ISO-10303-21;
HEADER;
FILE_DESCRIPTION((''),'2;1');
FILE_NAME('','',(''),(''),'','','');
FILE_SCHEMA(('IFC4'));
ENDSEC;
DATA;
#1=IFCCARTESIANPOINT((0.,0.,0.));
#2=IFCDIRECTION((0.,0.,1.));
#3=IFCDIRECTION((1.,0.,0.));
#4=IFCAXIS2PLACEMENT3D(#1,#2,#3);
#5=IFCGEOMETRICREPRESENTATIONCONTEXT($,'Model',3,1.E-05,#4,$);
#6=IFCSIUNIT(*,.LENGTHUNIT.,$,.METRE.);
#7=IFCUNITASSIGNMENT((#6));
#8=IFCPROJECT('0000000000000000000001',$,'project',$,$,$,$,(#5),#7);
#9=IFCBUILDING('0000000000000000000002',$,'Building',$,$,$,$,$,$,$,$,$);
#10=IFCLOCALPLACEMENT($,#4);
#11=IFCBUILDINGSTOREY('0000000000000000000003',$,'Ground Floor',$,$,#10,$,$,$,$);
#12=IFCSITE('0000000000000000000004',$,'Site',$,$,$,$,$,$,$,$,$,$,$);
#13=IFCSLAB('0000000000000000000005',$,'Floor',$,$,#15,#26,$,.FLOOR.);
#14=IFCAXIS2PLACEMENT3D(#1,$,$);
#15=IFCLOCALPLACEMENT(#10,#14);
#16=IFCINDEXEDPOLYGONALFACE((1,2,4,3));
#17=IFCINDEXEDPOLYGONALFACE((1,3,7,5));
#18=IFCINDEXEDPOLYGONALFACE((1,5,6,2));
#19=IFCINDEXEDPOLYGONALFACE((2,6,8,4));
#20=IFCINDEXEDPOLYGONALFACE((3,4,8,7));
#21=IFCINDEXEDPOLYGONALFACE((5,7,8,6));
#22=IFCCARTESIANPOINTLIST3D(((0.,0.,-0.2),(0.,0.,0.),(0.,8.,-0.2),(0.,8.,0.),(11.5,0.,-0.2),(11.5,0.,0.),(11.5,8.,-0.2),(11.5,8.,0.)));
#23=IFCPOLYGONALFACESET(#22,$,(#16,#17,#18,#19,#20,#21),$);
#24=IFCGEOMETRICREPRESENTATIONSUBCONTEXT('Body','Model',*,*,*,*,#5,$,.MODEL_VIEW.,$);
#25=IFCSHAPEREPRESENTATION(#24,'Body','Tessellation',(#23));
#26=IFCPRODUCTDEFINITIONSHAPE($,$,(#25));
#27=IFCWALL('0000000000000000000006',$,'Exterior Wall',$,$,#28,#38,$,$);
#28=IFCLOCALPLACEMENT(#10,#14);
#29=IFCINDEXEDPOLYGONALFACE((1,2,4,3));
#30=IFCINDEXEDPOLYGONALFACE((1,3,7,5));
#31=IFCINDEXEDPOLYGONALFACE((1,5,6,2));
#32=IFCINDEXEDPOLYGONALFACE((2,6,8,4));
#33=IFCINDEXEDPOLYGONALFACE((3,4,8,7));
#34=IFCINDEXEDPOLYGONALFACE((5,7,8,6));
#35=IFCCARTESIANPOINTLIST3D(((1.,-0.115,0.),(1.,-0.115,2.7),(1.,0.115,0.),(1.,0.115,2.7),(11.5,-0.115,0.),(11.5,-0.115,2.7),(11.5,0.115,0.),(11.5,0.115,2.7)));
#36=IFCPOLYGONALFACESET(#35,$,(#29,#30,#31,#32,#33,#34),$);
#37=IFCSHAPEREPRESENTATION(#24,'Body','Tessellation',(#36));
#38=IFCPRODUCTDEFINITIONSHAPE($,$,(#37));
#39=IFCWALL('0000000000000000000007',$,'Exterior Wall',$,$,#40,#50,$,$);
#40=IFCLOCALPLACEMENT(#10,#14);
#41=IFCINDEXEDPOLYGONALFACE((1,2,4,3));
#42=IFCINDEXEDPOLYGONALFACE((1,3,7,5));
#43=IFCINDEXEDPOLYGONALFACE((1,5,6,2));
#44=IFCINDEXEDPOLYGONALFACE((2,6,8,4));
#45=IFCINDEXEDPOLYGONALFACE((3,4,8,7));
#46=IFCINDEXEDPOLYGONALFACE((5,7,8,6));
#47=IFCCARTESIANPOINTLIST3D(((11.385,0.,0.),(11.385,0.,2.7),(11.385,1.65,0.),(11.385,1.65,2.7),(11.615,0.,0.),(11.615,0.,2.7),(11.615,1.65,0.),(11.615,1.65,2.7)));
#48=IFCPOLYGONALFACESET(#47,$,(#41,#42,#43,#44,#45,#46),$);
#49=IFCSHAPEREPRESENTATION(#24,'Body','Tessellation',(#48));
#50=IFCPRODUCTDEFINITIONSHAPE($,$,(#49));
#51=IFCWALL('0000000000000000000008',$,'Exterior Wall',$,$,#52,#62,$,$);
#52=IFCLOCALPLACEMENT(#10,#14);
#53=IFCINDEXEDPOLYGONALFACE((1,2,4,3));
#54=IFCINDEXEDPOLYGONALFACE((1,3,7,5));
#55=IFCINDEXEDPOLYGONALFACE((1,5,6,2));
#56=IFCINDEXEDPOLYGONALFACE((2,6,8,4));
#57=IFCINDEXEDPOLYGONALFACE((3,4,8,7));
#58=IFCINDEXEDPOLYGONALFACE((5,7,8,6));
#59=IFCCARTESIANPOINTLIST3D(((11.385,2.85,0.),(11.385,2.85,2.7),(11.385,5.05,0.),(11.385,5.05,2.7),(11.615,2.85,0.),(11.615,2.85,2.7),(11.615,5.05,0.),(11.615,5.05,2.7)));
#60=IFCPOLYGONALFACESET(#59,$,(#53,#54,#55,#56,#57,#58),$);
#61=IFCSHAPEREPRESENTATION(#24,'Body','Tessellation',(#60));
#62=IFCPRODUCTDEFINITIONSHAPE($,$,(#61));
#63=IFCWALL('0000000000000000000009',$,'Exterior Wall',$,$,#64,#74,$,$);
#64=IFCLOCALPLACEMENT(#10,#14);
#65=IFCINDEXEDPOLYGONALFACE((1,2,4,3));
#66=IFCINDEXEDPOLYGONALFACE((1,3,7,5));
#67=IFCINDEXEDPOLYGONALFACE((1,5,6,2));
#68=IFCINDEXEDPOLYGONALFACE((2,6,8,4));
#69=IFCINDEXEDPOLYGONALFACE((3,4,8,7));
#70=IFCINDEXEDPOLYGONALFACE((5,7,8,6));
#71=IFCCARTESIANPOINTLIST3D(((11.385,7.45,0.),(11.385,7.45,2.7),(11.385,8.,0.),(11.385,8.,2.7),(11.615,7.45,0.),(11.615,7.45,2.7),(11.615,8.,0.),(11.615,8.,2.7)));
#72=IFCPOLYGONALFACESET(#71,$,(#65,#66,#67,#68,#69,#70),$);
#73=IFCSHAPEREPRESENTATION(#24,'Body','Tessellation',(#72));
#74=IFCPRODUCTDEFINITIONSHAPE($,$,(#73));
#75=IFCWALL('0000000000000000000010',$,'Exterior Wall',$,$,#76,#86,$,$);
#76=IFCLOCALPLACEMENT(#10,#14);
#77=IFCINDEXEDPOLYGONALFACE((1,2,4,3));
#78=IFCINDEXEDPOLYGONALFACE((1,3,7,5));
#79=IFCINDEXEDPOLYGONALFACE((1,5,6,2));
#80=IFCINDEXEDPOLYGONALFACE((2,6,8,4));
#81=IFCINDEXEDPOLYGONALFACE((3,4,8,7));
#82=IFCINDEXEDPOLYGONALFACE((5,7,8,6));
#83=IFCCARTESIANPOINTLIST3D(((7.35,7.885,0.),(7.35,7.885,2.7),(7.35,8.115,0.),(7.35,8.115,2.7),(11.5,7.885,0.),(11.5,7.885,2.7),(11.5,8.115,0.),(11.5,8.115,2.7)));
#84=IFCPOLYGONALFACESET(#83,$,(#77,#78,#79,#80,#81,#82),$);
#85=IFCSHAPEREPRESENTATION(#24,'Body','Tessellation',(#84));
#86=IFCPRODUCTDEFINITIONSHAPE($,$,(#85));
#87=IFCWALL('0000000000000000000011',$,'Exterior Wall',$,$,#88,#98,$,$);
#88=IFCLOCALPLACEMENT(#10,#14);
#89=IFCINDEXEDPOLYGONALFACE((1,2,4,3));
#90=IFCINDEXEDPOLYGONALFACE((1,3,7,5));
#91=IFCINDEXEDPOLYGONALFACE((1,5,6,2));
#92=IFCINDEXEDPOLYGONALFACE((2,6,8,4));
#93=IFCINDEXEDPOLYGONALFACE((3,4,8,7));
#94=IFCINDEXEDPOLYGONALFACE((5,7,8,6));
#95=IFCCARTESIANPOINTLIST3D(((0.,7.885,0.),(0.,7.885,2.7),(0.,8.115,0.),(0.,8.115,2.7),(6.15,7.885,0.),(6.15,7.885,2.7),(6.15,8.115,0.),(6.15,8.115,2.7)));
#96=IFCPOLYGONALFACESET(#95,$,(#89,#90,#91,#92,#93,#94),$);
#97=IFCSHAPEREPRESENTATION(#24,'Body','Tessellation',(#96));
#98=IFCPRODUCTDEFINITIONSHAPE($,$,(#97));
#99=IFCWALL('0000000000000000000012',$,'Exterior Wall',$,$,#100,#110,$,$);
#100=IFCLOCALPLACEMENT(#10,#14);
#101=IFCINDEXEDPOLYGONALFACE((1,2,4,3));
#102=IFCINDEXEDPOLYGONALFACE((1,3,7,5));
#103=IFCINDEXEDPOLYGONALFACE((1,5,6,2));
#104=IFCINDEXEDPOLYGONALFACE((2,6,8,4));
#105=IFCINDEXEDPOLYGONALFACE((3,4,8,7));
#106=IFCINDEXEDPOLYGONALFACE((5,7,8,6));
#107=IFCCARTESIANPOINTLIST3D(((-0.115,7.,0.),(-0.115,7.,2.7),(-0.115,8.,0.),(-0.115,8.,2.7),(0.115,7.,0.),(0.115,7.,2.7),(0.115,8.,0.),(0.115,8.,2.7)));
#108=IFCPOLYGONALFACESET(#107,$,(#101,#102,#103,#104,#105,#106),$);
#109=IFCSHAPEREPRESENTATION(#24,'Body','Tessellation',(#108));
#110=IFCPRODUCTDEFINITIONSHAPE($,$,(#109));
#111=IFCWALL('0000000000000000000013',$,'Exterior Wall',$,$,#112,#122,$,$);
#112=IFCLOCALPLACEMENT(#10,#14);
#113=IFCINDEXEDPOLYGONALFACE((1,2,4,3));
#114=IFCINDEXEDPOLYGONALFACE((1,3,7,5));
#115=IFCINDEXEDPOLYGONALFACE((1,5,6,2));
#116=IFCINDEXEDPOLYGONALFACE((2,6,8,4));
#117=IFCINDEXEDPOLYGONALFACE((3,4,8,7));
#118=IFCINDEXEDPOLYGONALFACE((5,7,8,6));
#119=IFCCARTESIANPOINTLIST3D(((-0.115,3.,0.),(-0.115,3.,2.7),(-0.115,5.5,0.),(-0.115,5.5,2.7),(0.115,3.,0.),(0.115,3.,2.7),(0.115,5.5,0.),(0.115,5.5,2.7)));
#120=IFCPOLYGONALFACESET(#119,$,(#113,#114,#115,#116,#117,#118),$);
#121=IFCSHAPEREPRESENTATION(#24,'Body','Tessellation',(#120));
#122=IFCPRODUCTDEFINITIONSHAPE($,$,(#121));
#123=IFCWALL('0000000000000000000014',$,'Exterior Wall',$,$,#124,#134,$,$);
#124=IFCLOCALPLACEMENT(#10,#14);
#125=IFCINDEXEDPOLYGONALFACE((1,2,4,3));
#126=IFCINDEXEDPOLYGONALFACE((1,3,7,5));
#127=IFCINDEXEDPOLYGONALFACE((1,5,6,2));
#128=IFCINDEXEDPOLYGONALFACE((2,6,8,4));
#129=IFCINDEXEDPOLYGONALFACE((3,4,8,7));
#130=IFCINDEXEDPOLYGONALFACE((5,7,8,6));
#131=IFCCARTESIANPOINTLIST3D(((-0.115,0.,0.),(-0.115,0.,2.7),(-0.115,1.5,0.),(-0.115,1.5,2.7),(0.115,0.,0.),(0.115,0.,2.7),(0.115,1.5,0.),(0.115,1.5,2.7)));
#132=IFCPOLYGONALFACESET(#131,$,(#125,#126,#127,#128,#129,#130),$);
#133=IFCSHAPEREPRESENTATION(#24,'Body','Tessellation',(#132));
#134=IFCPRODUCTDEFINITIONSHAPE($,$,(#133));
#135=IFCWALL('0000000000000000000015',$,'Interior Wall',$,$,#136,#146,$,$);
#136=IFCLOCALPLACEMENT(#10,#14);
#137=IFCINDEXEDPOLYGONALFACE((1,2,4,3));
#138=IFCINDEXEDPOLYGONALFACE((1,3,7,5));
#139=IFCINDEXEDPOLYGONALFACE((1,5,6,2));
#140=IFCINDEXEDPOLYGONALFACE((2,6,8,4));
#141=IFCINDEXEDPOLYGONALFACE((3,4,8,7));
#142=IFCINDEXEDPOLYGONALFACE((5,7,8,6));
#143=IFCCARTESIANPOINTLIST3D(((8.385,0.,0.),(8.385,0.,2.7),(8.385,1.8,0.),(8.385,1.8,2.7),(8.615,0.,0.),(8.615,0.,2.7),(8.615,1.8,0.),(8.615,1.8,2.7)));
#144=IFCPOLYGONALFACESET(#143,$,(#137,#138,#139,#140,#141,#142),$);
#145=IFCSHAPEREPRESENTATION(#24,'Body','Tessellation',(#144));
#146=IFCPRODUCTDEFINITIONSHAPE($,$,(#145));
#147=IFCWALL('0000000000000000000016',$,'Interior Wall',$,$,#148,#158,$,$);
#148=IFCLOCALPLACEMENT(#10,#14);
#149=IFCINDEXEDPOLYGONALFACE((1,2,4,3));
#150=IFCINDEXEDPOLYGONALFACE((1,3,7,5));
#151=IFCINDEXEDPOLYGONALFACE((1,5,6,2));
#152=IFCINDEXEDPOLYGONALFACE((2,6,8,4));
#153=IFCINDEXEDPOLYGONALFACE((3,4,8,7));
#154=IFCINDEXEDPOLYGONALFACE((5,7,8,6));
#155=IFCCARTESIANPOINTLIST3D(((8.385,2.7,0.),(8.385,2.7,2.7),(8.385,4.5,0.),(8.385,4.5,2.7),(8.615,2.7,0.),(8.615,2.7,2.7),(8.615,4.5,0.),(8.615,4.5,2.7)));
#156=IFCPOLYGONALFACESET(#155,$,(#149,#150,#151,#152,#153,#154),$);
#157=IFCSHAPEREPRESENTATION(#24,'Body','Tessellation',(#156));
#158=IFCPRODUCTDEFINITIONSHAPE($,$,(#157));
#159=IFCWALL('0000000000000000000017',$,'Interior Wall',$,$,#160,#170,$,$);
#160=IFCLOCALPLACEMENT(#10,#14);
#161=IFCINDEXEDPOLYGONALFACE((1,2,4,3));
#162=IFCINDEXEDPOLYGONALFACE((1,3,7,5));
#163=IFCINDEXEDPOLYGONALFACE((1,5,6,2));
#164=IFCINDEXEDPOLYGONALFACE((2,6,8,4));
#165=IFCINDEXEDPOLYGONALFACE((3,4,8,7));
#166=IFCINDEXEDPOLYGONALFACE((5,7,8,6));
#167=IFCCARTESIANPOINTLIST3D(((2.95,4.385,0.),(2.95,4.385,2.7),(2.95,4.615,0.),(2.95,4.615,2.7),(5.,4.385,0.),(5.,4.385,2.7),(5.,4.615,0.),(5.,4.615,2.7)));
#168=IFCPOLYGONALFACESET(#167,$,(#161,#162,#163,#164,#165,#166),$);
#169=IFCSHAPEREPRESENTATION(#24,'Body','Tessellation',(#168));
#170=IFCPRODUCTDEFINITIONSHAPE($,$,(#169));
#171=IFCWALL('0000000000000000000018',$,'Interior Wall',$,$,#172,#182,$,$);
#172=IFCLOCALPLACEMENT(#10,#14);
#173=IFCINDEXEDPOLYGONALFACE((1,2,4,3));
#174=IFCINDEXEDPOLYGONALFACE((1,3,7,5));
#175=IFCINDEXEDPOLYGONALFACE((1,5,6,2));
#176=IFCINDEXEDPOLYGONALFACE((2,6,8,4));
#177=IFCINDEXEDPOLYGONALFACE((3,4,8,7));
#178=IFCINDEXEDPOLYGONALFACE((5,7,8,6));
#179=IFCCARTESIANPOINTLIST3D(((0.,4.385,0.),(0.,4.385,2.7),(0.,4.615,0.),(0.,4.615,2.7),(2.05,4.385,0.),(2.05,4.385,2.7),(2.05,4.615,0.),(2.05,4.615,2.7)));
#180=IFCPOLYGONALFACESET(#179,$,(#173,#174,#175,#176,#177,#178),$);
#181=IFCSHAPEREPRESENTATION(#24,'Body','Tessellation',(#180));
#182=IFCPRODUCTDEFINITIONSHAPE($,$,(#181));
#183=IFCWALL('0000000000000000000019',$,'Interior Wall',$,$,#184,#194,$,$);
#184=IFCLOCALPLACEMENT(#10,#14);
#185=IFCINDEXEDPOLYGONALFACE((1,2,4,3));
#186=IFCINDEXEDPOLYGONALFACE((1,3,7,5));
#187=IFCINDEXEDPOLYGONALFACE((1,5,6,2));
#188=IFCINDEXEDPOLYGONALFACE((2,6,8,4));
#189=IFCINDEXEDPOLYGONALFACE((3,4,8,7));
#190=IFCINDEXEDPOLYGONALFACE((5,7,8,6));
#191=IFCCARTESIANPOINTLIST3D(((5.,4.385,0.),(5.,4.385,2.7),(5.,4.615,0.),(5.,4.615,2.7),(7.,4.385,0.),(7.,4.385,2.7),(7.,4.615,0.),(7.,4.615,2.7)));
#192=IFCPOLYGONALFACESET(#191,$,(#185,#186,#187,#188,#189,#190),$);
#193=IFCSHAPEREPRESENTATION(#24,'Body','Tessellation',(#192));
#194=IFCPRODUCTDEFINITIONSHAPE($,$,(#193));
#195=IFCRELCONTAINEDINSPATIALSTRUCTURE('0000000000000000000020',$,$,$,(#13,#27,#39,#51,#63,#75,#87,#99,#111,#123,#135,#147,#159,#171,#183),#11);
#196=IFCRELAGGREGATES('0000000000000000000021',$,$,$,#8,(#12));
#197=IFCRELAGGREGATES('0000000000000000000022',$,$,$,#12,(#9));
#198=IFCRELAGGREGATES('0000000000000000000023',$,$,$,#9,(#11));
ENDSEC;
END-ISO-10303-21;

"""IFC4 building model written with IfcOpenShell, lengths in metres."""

from ifc_helpers import new_model, si_unit, frame, origin_with_axes, place, context, subcontext, project, spatial, indexed_curve, outline, extrude, element, save


model = new_model("IFC4")

# Units and contexts
model_context = context("Model", 3, precision=1e-05, world=origin_with_axes())
body_context = subcontext(model_context, "Body", "Model", "MODEL_VIEW")
ifc_project = project(units=[si_unit("LENGTHUNIT", "METRE")], contexts=[model_context])

# Site, building, storey
site = spatial("IfcSite", under=ifc_project, Name="Site")
building = spatial("IfcBuilding", under=site, Name="Building")
storey_placement = place(None, origin_with_axes())
storey = spatial("IfcBuildingStorey", under=building, at=storey_placement, Name="Ground Floor")

# Slab
slab_placement = place(storey_placement, frame((0.0, 0.0, -0.2), z_axis=(0.0, 0.0, 1.0), x_axis=(1.0, 0.0, 0.0)))
element("IfcSlab", 1, at=slab_placement, inside=storey, Name="Floor", PredefinedType="FLOOR", context=body_context, shape_type="SweptSolid", body=[
    extrude(outline(indexed_curve([(0.0, 0.0), (11.5, 0.0), (11.5, 8.0), (0.0, 8.0)])), None, (0.0, 0.0, 1.0), 0.2),
])

# Walls
wall_1_placement = place(storey_placement, frame((1.0, 0.0, 0.0), z_axis=(0.0, 0.0, 1.0), x_axis=(1.0, 0.0, 0.0)))
element("IfcWall", 2, at=wall_1_placement, inside=storey, Name="Exterior Wall", context=body_context, shape_type="SweptSolid", body=[
    extrude(outline(indexed_curve([(0.0, 0.0), (0.0, 0.23), (10.5, 0.23), (10.5, 0.0), (0.0, 0.0)], self_intersect=False)), frame((0.0, -0.115, 0.0), z_axis=(0.0, 0.0, 1.0), x_axis=(1.0, 0.0, 0.0)), (0.0, 0.0, 1.0), 2.7),
])
wall_2_placement = place(storey_placement, frame((11.5, 0.0, 0.0), z_axis=(0.0, 0.0, 1.0), x_axis=(0.0, 1.0, 0.0)))
element("IfcWall", 3, at=wall_2_placement, inside=storey, Name="Exterior Wall", context=body_context, shape_type="SweptSolid", body=[
    extrude(outline(indexed_curve([(0.0, 0.0), (0.0, 0.23), (1.65, 0.23), (1.65, 0.0), (0.0, 0.0)], self_intersect=False)), frame((0.0, -0.115, 0.0), z_axis=(0.0, 0.0, 1.0), x_axis=(1.0, 0.0, 0.0)), (0.0, 0.0, 1.0), 2.7),
])
wall_3_placement = place(storey_placement, frame((11.5, 2.85, 0.0), z_axis=(0.0, 0.0, 1.0), x_axis=(0.0, 1.0, 0.0)))
element("IfcWall", 4, at=wall_3_placement, inside=storey, Name="Exterior Wall", context=body_context, shape_type="SweptSolid", body=[
    extrude(outline(indexed_curve([(0.0, 0.0), (0.0, 0.23), (2.2, 0.23), (2.2, 0.0), (0.0, 0.0)], self_intersect=False)), frame((0.0, -0.115, 0.0), z_axis=(0.0, 0.0, 1.0), x_axis=(1.0, 0.0, 0.0)), (0.0, 0.0, 1.0), 2.7),
])
wall_4_placement = place(storey_placement, frame((11.5, 7.45, 0.0), z_axis=(0.0, 0.0, 1.0), x_axis=(0.0, 1.0, 0.0)))
element("IfcWall", 5, at=wall_4_placement, inside=storey, Name="Exterior Wall", context=body_context, shape_type="SweptSolid", body=[
    extrude(outline(indexed_curve([(0.0, 0.0), (0.0, 0.23), (0.55, 0.23), (0.55, 0.0), (0.0, 0.0)], self_intersect=False)), frame((0.0, -0.115, 0.0), z_axis=(0.0, 0.0, 1.0), x_axis=(1.0, 0.0, 0.0)), (0.0, 0.0, 1.0), 2.7),
])
wall_5_placement = place(storey_placement, frame((11.5, 8.0, 0.0), z_axis=(0.0, 0.0, 1.0), x_axis=(-1.0, 0.0, 0.0)))
element("IfcWall", 6, at=wall_5_placement, inside=storey, Name="Exterior Wall", context=body_context, shape_type="SweptSolid", body=[
    extrude(outline(indexed_curve([(0.0, 0.0), (0.0, 0.23), (4.15, 0.23), (4.15, 0.0), (0.0, 0.0)], self_intersect=False)), frame((0.0, -0.115, 0.0), z_axis=(0.0, 0.0, 1.0), x_axis=(1.0, 0.0, 0.0)), (0.0, 0.0, 1.0), 2.7),
])
wall_6_placement = place(storey_placement, frame((6.15, 8.0, 0.0), z_axis=(0.0, 0.0, 1.0), x_axis=(-1.0, 0.0, 0.0)))
element("IfcWall", 7, at=wall_6_placement, inside=storey, Name="Exterior Wall", context=body_context, shape_type="SweptSolid", body=[
    extrude(outline(indexed_curve([(0.0, 0.0), (0.0, 0.23), (6.15, 0.23), (6.15, 0.0), (0.0, 0.0)], self_intersect=False)), frame((0.0, -0.115, 0.0), z_axis=(0.0, 0.0, 1.0), x_axis=(1.0, 0.0, 0.0)), (0.0, 0.0, 1.0), 2.7),
])
wall_7_placement = place(storey_placement, frame((0.0, 8.0, 0.0), z_axis=(0.0, 0.0, 1.0), x_axis=(0.0, -1.0, 0.0)))
element("IfcWall", 8, at=wall_7_placement, inside=storey, Name="Exterior Wall", context=body_context, shape_type="SweptSolid", body=[
    extrude(outline(indexed_curve([(0.0, 0.0), (0.0, 0.23), (1.0, 0.23), (1.0, 0.0), (0.0, 0.0)], self_intersect=False)), frame((0.0, -0.115, 0.0), z_axis=(0.0, 0.0, 1.0), x_axis=(1.0, 0.0, 0.0)), (0.0, 0.0, 1.0), 2.7),
])
wall_8_placement = place(storey_placement, frame((0.0, 5.5, 0.0), z_axis=(0.0, 0.0, 1.0), x_axis=(0.0, -1.0, 0.0)))
element("IfcWall", 9, at=wall_8_placement, inside=storey, Name="Exterior Wall", context=body_context, shape_type="SweptSolid", body=[
    extrude(outline(indexed_curve([(0.0, 0.0), (0.0, 0.23), (2.5, 0.23), (2.5, 0.0), (0.0, 0.0)], self_intersect=False)), frame((0.0, -0.115, 0.0), z_axis=(0.0, 0.0, 1.0), x_axis=(1.0, 0.0, 0.0)), (0.0, 0.0, 1.0), 2.7),
])
wall_9_placement = place(storey_placement, frame((0.0, 1.5, 0.0), z_axis=(0.0, 0.0, 1.0), x_axis=(0.0, -1.0, 0.0)))
element("IfcWall", 10, at=wall_9_placement, inside=storey, Name="Exterior Wall", context=body_context, shape_type="SweptSolid", body=[
    extrude(outline(indexed_curve([(0.0, 0.0), (0.0, 0.23), (1.5, 0.23), (1.5, 0.0), (0.0, 0.0)], self_intersect=False)), frame((0.0, -0.115, 0.0), z_axis=(0.0, 0.0, 1.0), x_axis=(1.0, 0.0, 0.0)), (0.0, 0.0, 1.0), 2.7),
])
wall_10_placement = place(storey_placement, frame((8.5, 0.0, 0.0), z_axis=(0.0, 0.0, 1.0), x_axis=(0.0, 1.0, 0.0)))
element("IfcWall", 11, at=wall_10_placement, inside=storey, Name="Interior Wall", context=body_context, shape_type="SweptSolid", body=[
    extrude(outline(indexed_curve([(0.0, 0.0), (0.0, 0.23), (1.8, 0.23), (1.8, 0.0), (0.0, 0.0)], self_intersect=False)), frame((0.0, -0.115, 0.0), z_axis=(0.0, 0.0, 1.0), x_axis=(1.0, 0.0, 0.0)), (0.0, 0.0, 1.0), 2.7),
])
wall_11_placement = place(storey_placement, frame((8.5, 2.7, 0.0), z_axis=(0.0, 0.0, 1.0), x_axis=(0.0, 1.0, 0.0)))
element("IfcWall", 12, at=wall_11_placement, inside=storey, Name="Interior Wall", context=body_context, shape_type="SweptSolid", body=[
    extrude(outline(indexed_curve([(0.0, 0.0), (0.0, 0.23), (1.8, 0.23), (1.8, 0.0), (0.0, 0.0)], self_intersect=False)), frame((0.0, -0.115, 0.0), z_axis=(0.0, 0.0, 1.0), x_axis=(1.0, 0.0, 0.0)), (0.0, 0.0, 1.0), 2.7),
])
for number, where, z_axis, x_axis, name in (
    (13, (5.0, 4.5, 0.0), (0.0, 0.0, 1.0), (-1.0, 0.0, 0.0), "Interior Wall"),
    (14, (2.05, 4.5, 0.0), (0.0, 0.0, 1.0), (-1.0, 0.0, 0.0), "Interior Wall"),
):
    element("IfcWall", number, at=place(storey_placement, frame(where, z_axis=z_axis, x_axis=x_axis)), inside=storey, Name=name, context=body_context, shape_type="SweptSolid", body=[
        extrude(outline(indexed_curve([(0.0, 0.0), (0.0, 0.23), (2.05, 0.23), (2.05, 0.0), (0.0, 0.0)], self_intersect=False)), frame((0.0, -0.115, 0.0), z_axis=(0.0, 0.0, 1.0), x_axis=(1.0, 0.0, 0.0)), (0.0, 0.0, 1.0), 2.7),
    ])
wall_12_placement = place(storey_placement, frame((7.0, 4.5, 0.0), z_axis=(0.0, 0.0, 1.0), x_axis=(-1.0, 0.0, 0.0)))
element("IfcWall", 15, at=wall_12_placement, inside=storey, Name="Interior Wall", context=body_context, shape_type="SweptSolid", body=[
    extrude(outline(indexed_curve([(0.0, 0.0), (0.0, 0.23), (2.0, 0.23), (2.0, 0.0), (0.0, 0.0)], self_intersect=False)), frame((0.0, -0.115, 0.0), z_axis=(0.0, 0.0, 1.0), x_axis=(1.0, 0.0, 0.0)), (0.0, 0.0, 1.0), 2.7),
])

save(model, "model.ifc")
